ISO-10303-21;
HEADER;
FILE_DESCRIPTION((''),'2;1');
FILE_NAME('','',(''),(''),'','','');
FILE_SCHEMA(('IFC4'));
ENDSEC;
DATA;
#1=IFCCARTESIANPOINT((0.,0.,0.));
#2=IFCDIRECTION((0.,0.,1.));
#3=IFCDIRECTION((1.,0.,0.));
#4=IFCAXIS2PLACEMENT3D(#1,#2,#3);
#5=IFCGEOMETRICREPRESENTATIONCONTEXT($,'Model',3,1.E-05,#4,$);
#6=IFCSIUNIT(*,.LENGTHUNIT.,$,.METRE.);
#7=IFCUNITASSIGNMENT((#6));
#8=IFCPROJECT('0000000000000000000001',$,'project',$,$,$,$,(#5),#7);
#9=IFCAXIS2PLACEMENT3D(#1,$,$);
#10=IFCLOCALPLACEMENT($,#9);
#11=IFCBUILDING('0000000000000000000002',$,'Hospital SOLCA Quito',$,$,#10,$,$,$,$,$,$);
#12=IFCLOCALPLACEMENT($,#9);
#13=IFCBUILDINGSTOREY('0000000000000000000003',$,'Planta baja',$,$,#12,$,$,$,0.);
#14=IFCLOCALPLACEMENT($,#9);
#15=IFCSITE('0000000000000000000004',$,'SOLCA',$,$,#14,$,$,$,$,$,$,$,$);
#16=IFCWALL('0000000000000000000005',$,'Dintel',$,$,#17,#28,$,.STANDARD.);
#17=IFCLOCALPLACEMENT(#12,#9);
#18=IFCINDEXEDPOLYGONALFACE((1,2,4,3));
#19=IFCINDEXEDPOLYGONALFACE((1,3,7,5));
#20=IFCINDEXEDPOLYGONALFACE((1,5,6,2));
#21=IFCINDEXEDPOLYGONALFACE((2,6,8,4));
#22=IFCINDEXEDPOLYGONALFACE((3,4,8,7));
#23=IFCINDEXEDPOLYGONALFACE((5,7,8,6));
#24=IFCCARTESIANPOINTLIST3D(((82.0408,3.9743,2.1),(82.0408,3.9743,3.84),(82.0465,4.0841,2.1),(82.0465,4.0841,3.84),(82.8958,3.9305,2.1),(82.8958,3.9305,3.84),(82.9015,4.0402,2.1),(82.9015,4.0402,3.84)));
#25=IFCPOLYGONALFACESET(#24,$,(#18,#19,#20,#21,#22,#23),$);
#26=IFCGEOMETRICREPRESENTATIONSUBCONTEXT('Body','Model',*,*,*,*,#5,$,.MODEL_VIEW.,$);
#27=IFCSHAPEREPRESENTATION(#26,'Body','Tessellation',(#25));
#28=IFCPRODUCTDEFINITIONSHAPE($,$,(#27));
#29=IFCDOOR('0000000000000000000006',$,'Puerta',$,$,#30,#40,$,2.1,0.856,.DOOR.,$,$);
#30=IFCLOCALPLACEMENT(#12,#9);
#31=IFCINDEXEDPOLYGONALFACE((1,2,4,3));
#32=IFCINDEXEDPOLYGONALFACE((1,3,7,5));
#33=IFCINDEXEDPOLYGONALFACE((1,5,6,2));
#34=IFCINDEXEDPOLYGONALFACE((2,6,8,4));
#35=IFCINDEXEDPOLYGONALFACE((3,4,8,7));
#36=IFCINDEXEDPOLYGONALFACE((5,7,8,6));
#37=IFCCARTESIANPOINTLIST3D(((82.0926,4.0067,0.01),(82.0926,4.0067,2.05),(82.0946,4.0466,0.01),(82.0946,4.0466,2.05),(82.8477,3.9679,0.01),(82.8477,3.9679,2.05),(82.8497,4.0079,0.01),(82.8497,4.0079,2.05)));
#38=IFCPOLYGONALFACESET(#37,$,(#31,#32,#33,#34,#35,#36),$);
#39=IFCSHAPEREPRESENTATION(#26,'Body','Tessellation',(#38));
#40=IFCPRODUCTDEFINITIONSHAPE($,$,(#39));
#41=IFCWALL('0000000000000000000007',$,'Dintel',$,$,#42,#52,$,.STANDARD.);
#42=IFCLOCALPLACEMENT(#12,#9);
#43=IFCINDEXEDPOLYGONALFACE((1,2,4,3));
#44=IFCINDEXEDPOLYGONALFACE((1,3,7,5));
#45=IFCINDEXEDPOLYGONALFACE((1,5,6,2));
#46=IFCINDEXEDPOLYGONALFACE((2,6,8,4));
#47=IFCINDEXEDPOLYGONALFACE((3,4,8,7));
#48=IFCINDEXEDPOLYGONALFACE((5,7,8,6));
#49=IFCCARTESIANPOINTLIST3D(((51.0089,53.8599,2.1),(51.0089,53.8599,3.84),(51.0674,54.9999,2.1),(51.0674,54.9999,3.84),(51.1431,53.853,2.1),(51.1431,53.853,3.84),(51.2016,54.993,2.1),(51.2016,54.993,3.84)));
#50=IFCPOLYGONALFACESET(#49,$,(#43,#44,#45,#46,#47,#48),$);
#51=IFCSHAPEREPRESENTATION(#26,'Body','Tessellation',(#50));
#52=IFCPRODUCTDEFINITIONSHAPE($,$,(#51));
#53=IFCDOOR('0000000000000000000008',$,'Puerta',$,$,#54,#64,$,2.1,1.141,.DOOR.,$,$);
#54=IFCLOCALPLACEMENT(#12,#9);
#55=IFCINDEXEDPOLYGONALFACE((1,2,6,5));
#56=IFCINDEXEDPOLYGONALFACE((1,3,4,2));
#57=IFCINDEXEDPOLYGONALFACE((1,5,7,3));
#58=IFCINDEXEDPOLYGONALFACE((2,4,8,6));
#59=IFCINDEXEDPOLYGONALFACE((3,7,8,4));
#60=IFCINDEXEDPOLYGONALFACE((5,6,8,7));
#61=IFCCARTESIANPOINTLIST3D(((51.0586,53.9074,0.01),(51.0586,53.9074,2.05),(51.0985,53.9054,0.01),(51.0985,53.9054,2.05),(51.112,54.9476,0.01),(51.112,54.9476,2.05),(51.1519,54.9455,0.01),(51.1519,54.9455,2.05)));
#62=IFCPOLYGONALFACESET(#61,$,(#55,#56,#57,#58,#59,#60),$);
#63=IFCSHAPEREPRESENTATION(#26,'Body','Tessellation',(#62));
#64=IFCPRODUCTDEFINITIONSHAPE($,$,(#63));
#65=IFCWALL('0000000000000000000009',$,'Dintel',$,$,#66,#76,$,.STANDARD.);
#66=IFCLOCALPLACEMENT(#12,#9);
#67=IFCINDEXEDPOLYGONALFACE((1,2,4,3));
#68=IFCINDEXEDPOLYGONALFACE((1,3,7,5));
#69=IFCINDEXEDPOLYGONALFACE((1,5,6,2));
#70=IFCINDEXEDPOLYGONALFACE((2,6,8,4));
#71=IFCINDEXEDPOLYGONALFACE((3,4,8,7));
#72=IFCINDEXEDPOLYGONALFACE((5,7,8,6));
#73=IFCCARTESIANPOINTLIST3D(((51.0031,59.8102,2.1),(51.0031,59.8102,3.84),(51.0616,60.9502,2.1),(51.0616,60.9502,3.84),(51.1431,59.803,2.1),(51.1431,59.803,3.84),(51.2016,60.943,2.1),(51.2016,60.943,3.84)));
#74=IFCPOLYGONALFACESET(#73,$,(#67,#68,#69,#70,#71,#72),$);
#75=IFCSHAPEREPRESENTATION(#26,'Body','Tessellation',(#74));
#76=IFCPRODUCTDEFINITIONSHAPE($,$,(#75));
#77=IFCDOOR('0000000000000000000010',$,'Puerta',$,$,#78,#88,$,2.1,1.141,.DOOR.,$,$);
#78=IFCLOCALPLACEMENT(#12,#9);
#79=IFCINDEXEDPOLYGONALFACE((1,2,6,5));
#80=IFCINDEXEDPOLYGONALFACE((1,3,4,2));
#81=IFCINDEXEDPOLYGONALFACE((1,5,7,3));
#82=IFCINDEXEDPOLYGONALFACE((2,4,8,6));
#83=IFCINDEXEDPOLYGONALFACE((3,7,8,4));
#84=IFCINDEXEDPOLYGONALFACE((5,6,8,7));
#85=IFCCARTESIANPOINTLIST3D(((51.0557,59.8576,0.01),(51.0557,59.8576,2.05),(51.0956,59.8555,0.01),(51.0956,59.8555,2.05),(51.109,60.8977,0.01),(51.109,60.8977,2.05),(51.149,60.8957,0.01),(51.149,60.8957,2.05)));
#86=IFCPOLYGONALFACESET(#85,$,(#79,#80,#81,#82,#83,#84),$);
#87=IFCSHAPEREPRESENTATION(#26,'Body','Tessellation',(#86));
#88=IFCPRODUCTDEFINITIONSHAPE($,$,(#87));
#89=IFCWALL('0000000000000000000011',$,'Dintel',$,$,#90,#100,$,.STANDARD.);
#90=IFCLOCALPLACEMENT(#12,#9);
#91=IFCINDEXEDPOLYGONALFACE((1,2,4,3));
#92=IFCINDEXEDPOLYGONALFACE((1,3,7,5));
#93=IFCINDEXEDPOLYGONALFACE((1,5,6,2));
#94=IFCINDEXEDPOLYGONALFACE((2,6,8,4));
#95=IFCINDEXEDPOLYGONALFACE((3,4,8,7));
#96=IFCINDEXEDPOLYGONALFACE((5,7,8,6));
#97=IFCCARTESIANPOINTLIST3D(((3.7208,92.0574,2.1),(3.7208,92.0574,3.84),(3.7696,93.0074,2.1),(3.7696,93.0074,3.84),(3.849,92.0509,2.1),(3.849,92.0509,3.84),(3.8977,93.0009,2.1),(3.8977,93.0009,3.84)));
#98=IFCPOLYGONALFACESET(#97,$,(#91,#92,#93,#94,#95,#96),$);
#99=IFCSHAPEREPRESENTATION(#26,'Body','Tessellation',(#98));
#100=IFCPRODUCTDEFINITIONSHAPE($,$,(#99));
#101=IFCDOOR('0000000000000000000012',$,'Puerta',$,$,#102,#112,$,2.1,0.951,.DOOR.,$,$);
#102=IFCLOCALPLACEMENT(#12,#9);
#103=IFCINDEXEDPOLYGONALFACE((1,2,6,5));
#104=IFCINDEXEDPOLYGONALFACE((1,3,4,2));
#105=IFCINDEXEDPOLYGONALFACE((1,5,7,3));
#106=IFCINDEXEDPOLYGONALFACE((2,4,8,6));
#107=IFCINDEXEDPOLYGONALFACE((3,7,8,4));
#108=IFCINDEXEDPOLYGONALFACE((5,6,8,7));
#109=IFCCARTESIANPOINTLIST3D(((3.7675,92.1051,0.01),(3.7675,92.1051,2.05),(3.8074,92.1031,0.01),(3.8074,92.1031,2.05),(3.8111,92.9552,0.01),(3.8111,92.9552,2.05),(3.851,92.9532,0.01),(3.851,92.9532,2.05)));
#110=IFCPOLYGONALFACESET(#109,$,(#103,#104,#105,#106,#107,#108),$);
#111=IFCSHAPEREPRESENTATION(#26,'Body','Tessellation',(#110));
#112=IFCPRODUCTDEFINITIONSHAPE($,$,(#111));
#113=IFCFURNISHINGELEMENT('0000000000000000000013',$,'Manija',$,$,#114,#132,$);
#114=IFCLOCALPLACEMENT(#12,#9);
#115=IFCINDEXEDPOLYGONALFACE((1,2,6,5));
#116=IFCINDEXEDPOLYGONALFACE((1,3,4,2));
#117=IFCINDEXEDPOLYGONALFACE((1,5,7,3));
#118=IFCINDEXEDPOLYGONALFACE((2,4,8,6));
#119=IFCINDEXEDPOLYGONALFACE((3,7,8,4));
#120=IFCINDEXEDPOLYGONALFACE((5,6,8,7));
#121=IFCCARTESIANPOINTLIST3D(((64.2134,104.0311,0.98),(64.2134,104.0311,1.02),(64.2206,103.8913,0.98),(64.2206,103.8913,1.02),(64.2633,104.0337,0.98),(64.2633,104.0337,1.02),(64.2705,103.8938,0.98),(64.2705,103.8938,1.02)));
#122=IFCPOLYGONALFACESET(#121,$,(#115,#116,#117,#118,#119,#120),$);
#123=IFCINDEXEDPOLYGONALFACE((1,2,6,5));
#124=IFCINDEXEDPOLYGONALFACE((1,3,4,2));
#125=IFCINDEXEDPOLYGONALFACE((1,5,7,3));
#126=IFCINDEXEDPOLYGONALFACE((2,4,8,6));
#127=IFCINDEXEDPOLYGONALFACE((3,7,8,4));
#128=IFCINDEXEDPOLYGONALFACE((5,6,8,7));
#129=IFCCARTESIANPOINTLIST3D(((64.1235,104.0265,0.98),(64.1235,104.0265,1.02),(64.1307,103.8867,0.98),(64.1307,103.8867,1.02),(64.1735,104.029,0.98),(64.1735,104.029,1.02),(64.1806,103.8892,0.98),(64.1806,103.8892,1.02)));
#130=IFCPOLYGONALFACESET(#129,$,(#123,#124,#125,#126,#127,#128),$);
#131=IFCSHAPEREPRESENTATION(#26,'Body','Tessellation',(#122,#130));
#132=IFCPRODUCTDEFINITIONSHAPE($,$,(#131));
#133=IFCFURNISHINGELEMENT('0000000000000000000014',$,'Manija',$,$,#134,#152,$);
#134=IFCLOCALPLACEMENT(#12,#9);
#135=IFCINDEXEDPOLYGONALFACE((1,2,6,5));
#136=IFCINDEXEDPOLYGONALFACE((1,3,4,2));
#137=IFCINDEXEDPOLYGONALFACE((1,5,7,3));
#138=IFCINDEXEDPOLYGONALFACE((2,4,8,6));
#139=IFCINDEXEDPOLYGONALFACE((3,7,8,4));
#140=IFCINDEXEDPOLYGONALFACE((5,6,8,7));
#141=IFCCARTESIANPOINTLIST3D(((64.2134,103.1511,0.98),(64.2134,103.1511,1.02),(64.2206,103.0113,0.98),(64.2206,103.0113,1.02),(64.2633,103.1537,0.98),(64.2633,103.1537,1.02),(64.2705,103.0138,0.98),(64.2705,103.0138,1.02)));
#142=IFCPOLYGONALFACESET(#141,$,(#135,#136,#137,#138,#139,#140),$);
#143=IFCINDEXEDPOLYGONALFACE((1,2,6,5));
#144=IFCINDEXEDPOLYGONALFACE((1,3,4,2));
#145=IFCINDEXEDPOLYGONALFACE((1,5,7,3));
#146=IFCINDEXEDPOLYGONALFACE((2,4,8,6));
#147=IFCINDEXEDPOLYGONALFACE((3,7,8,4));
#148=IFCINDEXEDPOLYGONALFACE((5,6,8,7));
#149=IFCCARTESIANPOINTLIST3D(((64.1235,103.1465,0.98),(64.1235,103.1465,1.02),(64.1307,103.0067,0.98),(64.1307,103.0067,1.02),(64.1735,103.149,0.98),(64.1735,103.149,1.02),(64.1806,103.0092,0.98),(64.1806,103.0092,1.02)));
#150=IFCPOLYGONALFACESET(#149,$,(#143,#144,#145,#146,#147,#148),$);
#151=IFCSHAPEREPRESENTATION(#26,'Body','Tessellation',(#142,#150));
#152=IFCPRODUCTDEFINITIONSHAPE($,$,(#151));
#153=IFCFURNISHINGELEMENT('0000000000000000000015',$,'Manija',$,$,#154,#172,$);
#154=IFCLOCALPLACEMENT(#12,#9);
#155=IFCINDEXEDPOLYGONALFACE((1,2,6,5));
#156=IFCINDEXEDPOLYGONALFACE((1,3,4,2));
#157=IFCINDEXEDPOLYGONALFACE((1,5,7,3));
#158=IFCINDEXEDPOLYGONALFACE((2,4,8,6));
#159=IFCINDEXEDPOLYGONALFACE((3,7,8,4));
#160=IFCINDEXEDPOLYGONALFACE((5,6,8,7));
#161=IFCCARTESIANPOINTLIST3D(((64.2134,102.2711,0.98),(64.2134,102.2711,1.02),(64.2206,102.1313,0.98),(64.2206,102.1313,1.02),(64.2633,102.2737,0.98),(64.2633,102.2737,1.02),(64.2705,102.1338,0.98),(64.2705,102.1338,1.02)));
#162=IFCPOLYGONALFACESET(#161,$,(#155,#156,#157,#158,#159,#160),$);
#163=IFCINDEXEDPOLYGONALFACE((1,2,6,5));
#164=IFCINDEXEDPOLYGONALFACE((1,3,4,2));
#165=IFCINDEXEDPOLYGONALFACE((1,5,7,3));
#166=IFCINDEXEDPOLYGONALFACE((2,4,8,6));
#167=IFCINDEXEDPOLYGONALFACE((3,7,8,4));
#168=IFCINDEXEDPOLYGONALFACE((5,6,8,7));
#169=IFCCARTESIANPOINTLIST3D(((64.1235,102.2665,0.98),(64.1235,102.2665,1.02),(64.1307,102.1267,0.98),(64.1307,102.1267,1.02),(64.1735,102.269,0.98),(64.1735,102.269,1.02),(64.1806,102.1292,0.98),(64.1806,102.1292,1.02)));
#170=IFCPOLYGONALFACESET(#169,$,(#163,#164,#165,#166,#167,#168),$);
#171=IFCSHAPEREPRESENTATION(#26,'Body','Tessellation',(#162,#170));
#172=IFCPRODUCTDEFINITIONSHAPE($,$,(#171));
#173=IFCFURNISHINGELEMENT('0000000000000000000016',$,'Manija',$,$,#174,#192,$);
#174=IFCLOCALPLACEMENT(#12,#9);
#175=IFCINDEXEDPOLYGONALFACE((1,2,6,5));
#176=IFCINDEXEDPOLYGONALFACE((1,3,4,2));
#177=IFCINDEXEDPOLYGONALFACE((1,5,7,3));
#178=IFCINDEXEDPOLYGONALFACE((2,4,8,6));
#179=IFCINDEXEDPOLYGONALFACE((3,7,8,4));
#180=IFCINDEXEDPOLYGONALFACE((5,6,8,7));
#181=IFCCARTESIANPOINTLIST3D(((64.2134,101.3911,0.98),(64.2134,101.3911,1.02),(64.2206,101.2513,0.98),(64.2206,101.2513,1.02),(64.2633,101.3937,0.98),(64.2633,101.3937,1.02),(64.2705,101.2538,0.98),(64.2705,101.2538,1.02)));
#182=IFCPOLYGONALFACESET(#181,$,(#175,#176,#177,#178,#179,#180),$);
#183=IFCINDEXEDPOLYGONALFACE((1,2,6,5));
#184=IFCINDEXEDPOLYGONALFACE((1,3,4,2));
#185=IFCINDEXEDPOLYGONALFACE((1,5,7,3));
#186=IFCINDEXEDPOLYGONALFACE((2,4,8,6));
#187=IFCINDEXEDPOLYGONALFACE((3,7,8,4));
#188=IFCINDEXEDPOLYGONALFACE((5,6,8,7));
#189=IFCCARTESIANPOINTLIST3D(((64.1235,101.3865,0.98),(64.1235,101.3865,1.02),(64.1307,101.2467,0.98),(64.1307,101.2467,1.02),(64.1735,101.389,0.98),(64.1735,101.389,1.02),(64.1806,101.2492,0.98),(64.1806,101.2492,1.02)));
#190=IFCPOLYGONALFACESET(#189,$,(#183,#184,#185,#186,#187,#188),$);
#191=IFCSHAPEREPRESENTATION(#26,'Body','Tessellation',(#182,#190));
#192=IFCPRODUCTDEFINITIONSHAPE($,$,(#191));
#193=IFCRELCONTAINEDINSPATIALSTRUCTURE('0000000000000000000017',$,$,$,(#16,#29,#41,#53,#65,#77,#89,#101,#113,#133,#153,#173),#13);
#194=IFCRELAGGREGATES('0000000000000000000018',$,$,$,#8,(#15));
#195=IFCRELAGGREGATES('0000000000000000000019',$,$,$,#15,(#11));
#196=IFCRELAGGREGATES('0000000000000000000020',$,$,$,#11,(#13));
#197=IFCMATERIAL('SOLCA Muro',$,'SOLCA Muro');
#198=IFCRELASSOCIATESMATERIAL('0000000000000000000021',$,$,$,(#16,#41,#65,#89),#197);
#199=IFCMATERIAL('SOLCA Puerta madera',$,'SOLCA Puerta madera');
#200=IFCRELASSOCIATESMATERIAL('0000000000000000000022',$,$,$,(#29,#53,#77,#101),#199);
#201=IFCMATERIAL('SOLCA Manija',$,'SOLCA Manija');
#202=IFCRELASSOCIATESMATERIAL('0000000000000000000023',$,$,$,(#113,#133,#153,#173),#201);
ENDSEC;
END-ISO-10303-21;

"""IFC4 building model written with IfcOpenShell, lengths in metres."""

from ifc_helpers import new_model, si_unit, frame, origin, origin_with_axes, place, context, subcontext, project, spatial, polyline, outline, extrude, material, element, save


model = new_model("IFC4")

# Units and contexts
model_context = context("Model", 3, precision=1e-05, world=origin_with_axes())
body_context = subcontext(model_context, "Body", "Model", "MODEL_VIEW")
ifc_project = project(units=[si_unit("LENGTHUNIT", "METRE")], contexts=[model_context])

# Site, building, storey
site_placement = place(None, origin())
site = spatial("IfcSite", under=ifc_project, at=site_placement, Name="SOLCA")
building_placement = place(None, origin())
building = spatial("IfcBuilding", under=site, at=building_placement, Name="Hospital SOLCA Quito")
storey_placement = place(None, origin())
storey = spatial("IfcBuildingStorey", under=building, at=storey_placement, Name="Planta baja", Elevation=0.0)

# Shared definitions
ifc_material_1 = material(Name="SOLCA Muro", Category="SOLCA Muro")

# Shared definitions
ifc_material_2 = material(Name="SOLCA Puerta madera", Category="SOLCA Puerta madera")

# Wall
wall_1_placement = place(storey_placement, origin_with_axes())
element("IfcWall", 1, at=wall_1_placement, inside=storey, material=ifc_material_1, Name="Dintel", PredefinedType="STANDARD", context=body_context, shape_type="SweptSolid", body=[
    extrude(outline(polyline([(82.9015, 4.0402), (82.0465, 4.0841), (82.0408, 3.9743), (82.8958, 3.9305), (82.9015, 4.0402)])), frame((0.0, 0.0, 2.1), z_axis=(0.0, 0.0, 1.0), x_axis=(1.0, 0.0, 0.0)), (0.0, 0.0, 1.0), 1.74),
])

# Door
door_1_placement = place(storey_placement, origin_with_axes())
element("IfcDoor", 2, at=door_1_placement, inside=storey, material=ifc_material_2, Name="Puerta", OverallHeight=2.1, OverallWidth=0.856, PredefinedType="DOOR", context=body_context, shape_type="SweptSolid", body=[
    extrude(outline(polyline([(82.8497, 4.0079), (82.0946, 4.0466), (82.0926, 4.0067), (82.8477, 3.9679), (82.8497, 4.0079)])), frame((0.0, 0.0, 0.01), z_axis=(0.0, 0.0, 1.0), x_axis=(1.0, 0.0, 0.0)), (0.0, 0.0, 1.0), 2.04),
])

# Wall
wall_2_placement = place(storey_placement, origin_with_axes())
element("IfcWall", 3, at=wall_2_placement, inside=storey, material=ifc_material_1, Name="Dintel", PredefinedType="STANDARD", context=body_context, shape_type="SweptSolid", body=[
    extrude(outline(polyline([(51.1431, 53.853), (51.2016, 54.993), (51.0674, 54.9999), (51.0089, 53.8599), (51.1431, 53.853)])), frame((0.0, 0.0, 2.1), z_axis=(0.0, 0.0, 1.0), x_axis=(1.0, 0.0, 0.0)), (0.0, 0.0, 1.0), 1.74),
])

# Door
door_2_placement = place(storey_placement, origin_with_axes())
element("IfcDoor", 4, at=door_2_placement, inside=storey, material=ifc_material_2, Name="Puerta", OverallHeight=2.1, OverallWidth=1.141, PredefinedType="DOOR", context=body_context, shape_type="SweptSolid", body=[
    extrude(outline(polyline([(51.0985, 53.9054), (51.1519, 54.9455), (51.112, 54.9476), (51.0586, 53.9074), (51.0985, 53.9054)])), frame((0.0, 0.0, 0.01), z_axis=(0.0, 0.0, 1.0), x_axis=(1.0, 0.0, 0.0)), (0.0, 0.0, 1.0), 2.04),
])

# Wall
wall_3_placement = place(storey_placement, origin_with_axes())
element("IfcWall", 5, at=wall_3_placement, inside=storey, material=ifc_material_1, Name="Dintel", PredefinedType="STANDARD", context=body_context, shape_type="SweptSolid", body=[
    extrude(outline(polyline([(51.1431, 59.803), (51.2016, 60.943), (51.0616, 60.9502), (51.0031, 59.8102), (51.1431, 59.803)])), frame((0.0, 0.0, 2.1), z_axis=(0.0, 0.0, 1.0), x_axis=(1.0, 0.0, 0.0)), (0.0, 0.0, 1.0), 1.74),
])

# Door
door_3_placement = place(storey_placement, origin_with_axes())
element("IfcDoor", 6, at=door_3_placement, inside=storey, material=ifc_material_2, Name="Puerta", OverallHeight=2.1, OverallWidth=1.141, PredefinedType="DOOR", context=body_context, shape_type="SweptSolid", body=[
    extrude(outline(polyline([(51.0956, 59.8555), (51.149, 60.8957), (51.109, 60.8977), (51.0557, 59.8576), (51.0956, 59.8555)])), frame((0.0, 0.0, 0.01), z_axis=(0.0, 0.0, 1.0), x_axis=(1.0, 0.0, 0.0)), (0.0, 0.0, 1.0), 2.04),
])

# Wall
wall_4_placement = place(storey_placement, origin_with_axes())
element("IfcWall", 7, at=wall_4_placement, inside=storey, material=ifc_material_1, Name="Dintel", PredefinedType="STANDARD", context=body_context, shape_type="SweptSolid", body=[
    extrude(outline(polyline([(3.7696, 93.0074), (3.7208, 92.0574), (3.849, 92.0509), (3.8977, 93.0009), (3.7696, 93.0074)])), frame((0.0, 0.0, 2.1), z_axis=(0.0, 0.0, 1.0), x_axis=(1.0, 0.0, 0.0)), (0.0, 0.0, 1.0), 1.74),
])

# Door
door_4_placement = place(storey_placement, origin_with_axes())
element("IfcDoor", 8, at=door_4_placement, inside=storey, material=ifc_material_2, Name="Puerta", OverallHeight=2.1, OverallWidth=0.951, PredefinedType="DOOR", context=body_context, shape_type="SweptSolid", body=[
    extrude(outline(polyline([(3.8111, 92.9552), (3.7675, 92.1051), (3.8074, 92.1031), (3.851, 92.9532), (3.8111, 92.9552)])), frame((0.0, 0.0, 0.01), z_axis=(0.0, 0.0, 1.0), x_axis=(1.0, 0.0, 0.0)), (0.0, 0.0, 1.0), 2.04),
])

# Furnishing elements
ifc_material_3 = material(Name="SOLCA Manija", Category="SOLCA Manija")
furnishing_1_placement = place(storey_placement, origin_with_axes())
element("IfcFurnishingElement", 9, at=furnishing_1_placement, inside=storey, material=ifc_material_3, Name="Manija", context=body_context, shape_type="SweptSolid", body=[
    extrude(outline(polyline([(64.2705, 103.8938), (64.2633, 104.0337), (64.2134, 104.0311), (64.2206, 103.8913), (64.2705, 103.8938)])), frame((0.0, 0.0, 0.98), z_axis=(0.0, 0.0, 1.0), x_axis=(1.0, 0.0, 0.0)), (0.0, 0.0, 1.0), 0.04),
    extrude(outline(polyline([(64.1806, 103.8892), (64.1735, 104.029), (64.1235, 104.0265), (64.1307, 103.8867), (64.1806, 103.8892)])), frame((0.0, 0.0, 0.98), z_axis=(0.0, 0.0, 1.0), x_axis=(1.0, 0.0, 0.0)), (0.0, 0.0, 1.0), 0.04),
])
furnishing_2_placement = place(storey_placement, origin_with_axes())
element("IfcFurnishingElement", 10, at=furnishing_2_placement, inside=storey, material=ifc_material_3, Name="Manija", context=body_context, shape_type="SweptSolid", body=[
    extrude(outline(polyline([(64.2705, 103.0138), (64.2633, 103.1537), (64.2134, 103.1511), (64.2206, 103.0113), (64.2705, 103.0138)])), frame((0.0, 0.0, 0.98), z_axis=(0.0, 0.0, 1.0), x_axis=(1.0, 0.0, 0.0)), (0.0, 0.0, 1.0), 0.04),
    extrude(outline(polyline([(64.1806, 103.0092), (64.1735, 103.149), (64.1235, 103.1465), (64.1307, 103.0067), (64.1806, 103.0092)])), frame((0.0, 0.0, 0.98), z_axis=(0.0, 0.0, 1.0), x_axis=(1.0, 0.0, 0.0)), (0.0, 0.0, 1.0), 0.04),
])
furnishing_3_placement = place(storey_placement, origin_with_axes())
element("IfcFurnishingElement", 11, at=furnishing_3_placement, inside=storey, material=ifc_material_3, Name="Manija", context=body_context, shape_type="SweptSolid", body=[
    extrude(outline(polyline([(64.2705, 102.1338), (64.2633, 102.2737), (64.2134, 102.2711), (64.2206, 102.1313), (64.2705, 102.1338)])), frame((0.0, 0.0, 0.98), z_axis=(0.0, 0.0, 1.0), x_axis=(1.0, 0.0, 0.0)), (0.0, 0.0, 1.0), 0.04),
    extrude(outline(polyline([(64.1806, 102.1292), (64.1735, 102.269), (64.1235, 102.2665), (64.1307, 102.1267), (64.1806, 102.1292)])), frame((0.0, 0.0, 0.98), z_axis=(0.0, 0.0, 1.0), x_axis=(1.0, 0.0, 0.0)), (0.0, 0.0, 1.0), 0.04),
])
furnishing_4_placement = place(storey_placement, origin_with_axes())
element("IfcFurnishingElement", 12, at=furnishing_4_placement, inside=storey, material=ifc_material_3, Name="Manija", context=body_context, shape_type="SweptSolid", body=[
    extrude(outline(polyline([(64.2705, 101.2538), (64.2633, 101.3937), (64.2134, 101.3911), (64.2206, 101.2513), (64.2705, 101.2538)])), frame((0.0, 0.0, 0.98), z_axis=(0.0, 0.0, 1.0), x_axis=(1.0, 0.0, 0.0)), (0.0, 0.0, 1.0), 0.04),
    extrude(outline(polyline([(64.1806, 101.2492), (64.1735, 101.389), (64.1235, 101.3865), (64.1307, 101.2467), (64.1806, 101.2492)])), frame((0.0, 0.0, 0.98), z_axis=(0.0, 0.0, 1.0), x_axis=(1.0, 0.0, 0.0)), (0.0, 0.0, 1.0), 0.04),
])

save(model, "model.ifc")
